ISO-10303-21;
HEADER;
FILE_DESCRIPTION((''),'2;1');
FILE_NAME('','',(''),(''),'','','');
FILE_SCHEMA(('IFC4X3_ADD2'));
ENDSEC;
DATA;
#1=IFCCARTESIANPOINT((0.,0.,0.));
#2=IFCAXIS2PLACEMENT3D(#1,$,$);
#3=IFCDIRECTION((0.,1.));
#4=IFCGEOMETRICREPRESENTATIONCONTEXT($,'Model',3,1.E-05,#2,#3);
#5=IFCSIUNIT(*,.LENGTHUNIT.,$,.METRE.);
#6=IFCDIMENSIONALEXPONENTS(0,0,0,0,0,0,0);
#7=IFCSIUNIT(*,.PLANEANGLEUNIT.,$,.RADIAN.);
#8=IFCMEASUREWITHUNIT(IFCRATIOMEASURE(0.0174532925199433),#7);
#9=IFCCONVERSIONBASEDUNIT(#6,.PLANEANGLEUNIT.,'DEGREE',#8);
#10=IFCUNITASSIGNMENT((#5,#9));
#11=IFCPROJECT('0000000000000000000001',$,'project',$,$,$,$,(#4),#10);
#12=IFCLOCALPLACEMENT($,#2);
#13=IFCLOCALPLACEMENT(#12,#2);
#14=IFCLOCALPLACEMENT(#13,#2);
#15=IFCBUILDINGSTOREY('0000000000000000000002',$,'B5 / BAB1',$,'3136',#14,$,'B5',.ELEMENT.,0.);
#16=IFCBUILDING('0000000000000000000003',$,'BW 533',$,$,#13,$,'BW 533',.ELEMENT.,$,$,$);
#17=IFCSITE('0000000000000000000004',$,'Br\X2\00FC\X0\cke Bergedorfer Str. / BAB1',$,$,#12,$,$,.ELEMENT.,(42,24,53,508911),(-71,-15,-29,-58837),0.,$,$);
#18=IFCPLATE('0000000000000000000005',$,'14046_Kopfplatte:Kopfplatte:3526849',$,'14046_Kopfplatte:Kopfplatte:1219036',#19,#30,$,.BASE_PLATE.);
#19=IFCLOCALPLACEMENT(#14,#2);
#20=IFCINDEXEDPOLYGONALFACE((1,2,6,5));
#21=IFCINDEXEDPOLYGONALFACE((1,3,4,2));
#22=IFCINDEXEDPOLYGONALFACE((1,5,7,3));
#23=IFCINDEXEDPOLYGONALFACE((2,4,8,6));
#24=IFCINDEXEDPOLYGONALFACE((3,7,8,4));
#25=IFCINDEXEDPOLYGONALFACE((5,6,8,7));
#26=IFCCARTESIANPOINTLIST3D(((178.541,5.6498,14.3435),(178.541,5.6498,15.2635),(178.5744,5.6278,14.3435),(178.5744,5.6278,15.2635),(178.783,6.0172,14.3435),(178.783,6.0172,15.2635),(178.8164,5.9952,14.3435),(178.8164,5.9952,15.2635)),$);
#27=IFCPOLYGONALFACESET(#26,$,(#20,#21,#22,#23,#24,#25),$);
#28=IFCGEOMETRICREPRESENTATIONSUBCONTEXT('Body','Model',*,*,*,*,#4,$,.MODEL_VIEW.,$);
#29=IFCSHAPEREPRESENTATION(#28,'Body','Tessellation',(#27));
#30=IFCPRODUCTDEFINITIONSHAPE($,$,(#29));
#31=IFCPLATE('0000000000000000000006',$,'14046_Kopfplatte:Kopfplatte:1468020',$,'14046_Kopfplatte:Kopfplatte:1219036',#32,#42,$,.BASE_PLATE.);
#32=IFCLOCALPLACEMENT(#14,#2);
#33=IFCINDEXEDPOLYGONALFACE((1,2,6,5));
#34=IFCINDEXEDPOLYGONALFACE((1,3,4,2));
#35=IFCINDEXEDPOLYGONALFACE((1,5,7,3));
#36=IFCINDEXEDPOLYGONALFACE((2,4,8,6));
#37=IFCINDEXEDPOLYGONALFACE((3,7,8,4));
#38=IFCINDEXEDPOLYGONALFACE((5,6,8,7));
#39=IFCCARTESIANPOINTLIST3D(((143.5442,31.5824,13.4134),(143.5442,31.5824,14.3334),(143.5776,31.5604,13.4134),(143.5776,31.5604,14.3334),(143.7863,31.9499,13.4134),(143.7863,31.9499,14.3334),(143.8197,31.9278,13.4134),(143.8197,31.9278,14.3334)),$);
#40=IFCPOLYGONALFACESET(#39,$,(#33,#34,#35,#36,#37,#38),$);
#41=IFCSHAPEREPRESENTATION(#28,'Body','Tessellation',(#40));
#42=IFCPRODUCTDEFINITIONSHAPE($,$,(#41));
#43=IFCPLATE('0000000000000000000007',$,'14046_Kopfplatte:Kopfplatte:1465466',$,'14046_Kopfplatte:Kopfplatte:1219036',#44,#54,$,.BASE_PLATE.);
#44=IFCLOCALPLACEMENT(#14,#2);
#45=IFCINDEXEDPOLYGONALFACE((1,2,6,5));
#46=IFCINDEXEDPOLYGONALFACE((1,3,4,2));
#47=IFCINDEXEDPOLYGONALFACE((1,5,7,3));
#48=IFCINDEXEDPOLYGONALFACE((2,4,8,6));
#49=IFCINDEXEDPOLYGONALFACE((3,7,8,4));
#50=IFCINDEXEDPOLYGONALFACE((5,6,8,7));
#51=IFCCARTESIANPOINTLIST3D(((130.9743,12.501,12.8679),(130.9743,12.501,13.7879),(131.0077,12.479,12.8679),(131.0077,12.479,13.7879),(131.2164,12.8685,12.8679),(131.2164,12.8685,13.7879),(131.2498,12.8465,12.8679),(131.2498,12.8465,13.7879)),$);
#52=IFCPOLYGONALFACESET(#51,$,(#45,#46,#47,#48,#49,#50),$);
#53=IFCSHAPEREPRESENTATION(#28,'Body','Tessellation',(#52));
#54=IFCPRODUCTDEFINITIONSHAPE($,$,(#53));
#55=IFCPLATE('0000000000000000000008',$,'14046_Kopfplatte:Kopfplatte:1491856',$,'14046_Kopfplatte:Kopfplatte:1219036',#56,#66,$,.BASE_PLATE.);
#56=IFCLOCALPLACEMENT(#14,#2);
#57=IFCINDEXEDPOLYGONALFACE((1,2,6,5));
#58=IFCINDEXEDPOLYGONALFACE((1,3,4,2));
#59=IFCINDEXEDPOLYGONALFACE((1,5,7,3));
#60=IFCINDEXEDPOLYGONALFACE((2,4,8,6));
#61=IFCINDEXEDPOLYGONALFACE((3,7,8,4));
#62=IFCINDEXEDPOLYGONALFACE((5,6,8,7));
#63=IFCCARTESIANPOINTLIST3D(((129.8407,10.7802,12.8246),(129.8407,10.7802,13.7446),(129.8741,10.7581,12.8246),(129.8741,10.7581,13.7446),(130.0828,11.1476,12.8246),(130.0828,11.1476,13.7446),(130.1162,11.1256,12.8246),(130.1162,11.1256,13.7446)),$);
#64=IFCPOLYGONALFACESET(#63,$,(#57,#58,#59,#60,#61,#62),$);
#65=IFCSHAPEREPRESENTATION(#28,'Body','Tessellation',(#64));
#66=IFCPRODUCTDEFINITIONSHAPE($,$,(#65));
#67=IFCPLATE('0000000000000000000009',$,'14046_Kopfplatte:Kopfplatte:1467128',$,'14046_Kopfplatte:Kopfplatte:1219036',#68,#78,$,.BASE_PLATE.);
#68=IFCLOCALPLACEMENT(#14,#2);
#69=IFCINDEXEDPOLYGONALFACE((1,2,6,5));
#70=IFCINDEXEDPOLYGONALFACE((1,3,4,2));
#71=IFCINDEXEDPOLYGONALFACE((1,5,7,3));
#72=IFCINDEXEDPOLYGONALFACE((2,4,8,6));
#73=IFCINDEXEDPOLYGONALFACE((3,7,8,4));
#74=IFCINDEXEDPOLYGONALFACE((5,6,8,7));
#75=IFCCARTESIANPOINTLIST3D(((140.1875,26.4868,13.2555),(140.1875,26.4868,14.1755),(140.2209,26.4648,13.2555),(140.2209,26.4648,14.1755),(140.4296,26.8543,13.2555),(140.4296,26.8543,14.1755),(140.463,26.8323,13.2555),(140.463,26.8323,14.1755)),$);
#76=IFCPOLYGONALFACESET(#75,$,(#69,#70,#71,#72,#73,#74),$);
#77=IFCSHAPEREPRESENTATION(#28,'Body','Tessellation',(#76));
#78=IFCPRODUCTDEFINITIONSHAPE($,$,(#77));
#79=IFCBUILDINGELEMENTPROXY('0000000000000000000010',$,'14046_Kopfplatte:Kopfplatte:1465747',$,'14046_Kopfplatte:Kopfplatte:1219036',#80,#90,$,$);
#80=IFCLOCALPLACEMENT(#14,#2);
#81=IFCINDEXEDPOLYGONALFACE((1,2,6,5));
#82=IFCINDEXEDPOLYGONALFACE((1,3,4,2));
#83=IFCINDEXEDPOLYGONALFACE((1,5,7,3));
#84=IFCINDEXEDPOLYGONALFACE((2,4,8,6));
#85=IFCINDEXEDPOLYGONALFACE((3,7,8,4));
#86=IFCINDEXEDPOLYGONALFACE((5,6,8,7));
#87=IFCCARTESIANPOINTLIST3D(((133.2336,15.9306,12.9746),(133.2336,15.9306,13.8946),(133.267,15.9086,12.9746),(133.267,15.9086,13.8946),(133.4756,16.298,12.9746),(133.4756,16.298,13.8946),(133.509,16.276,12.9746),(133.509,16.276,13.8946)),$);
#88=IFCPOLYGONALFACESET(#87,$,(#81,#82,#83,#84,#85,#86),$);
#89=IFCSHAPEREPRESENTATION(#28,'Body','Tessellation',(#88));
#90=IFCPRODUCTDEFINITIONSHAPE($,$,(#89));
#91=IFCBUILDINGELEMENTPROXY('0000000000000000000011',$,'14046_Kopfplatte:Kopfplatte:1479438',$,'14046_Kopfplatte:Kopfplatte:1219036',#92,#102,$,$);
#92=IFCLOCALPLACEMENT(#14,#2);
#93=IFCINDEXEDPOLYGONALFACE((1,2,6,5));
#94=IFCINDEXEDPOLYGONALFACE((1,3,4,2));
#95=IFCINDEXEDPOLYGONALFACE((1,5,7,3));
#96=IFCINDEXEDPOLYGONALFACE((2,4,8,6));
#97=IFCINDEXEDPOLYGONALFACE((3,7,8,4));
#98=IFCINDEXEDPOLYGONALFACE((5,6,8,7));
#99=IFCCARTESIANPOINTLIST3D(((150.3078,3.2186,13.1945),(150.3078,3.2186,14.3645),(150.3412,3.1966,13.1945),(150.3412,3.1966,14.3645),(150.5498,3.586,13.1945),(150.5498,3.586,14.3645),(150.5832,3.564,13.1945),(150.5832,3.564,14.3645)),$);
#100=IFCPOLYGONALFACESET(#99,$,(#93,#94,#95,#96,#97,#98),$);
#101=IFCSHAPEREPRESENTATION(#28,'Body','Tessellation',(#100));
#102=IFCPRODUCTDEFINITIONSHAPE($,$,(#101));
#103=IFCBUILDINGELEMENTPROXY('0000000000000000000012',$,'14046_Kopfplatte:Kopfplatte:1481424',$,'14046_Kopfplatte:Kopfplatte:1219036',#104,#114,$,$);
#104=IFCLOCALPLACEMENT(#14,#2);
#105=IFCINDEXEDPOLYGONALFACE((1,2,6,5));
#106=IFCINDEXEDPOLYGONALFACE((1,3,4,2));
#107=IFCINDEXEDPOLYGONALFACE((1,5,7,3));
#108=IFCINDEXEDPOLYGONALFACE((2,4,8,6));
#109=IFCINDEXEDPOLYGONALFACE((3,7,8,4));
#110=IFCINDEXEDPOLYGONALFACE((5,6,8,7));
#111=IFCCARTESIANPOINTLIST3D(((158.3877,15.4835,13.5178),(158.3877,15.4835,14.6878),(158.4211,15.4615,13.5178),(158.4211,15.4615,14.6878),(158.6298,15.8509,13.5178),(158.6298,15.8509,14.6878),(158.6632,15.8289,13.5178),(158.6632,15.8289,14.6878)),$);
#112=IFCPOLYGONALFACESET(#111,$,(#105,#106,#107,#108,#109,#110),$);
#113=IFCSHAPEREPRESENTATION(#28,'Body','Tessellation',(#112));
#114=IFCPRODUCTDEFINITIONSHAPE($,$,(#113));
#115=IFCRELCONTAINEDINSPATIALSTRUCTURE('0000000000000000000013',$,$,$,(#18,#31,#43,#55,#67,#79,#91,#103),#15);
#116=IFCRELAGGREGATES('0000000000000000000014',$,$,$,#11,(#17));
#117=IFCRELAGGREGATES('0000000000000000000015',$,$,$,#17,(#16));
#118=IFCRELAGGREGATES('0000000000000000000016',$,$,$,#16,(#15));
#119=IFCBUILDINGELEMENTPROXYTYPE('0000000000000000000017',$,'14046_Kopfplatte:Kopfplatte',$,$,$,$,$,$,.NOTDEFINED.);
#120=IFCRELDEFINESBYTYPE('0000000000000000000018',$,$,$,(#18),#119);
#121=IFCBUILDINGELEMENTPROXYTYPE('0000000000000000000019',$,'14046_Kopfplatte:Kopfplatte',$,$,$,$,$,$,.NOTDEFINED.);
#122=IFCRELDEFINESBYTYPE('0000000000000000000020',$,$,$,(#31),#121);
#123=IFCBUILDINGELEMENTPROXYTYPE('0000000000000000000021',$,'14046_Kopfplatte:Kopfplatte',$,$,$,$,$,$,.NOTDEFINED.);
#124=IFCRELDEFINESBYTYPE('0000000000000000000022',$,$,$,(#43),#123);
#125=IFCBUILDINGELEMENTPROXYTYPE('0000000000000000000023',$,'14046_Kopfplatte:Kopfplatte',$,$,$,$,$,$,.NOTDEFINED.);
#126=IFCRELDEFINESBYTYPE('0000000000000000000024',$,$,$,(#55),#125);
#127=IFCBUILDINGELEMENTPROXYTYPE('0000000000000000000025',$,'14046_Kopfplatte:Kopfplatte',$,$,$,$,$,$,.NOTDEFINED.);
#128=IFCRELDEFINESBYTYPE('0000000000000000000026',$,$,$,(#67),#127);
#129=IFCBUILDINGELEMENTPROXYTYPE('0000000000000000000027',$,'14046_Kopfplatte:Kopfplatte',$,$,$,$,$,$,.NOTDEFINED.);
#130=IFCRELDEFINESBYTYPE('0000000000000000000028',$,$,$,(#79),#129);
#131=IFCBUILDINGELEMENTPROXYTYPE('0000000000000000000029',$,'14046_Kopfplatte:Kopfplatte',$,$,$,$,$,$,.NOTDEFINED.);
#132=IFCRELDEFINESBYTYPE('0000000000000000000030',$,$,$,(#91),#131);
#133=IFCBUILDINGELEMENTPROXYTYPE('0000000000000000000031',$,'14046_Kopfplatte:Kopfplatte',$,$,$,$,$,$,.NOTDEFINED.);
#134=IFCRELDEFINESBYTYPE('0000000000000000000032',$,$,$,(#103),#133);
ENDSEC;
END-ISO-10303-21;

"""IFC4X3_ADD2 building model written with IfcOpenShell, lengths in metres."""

from ifc_helpers import new_model, entity, si_unit, converted_unit, direction, frame, frame_2d, origin, origin_2d_with_axis, place, context, subcontext, project, spatial, rectangle, extrude, source, transform, mapped, type_object, type_shapes, element, save


model = new_model("IFC4X3_ADD2")

# Units and contexts
model_context = context("Model", 3, precision=1e-05, world=origin(), true_north=direction((0.0, 1.0)))
body_context = subcontext(model_context, "Body", "Model", "MODEL_VIEW")
ifc_project = project(units=[si_unit("LENGTHUNIT", "METRE"), converted_unit("PLANEANGLEUNIT", "DEGREE", entity("IfcRatioMeasure", 0.0174532925199433), si_unit("PLANEANGLEUNIT", "RADIAN"), dimensions=[0, 0, 0, 0, 0, 0, 0])], contexts=[model_context])

# Site, building, storey
site_placement = place(None, origin())
site = spatial("IfcSite", under=ifc_project, at=site_placement, Name="Brücke Bergedorfer Str. / BAB1", CompositionType="ELEMENT", RefLatitude=(42, 24, 53, 508911), RefLongitude=(-71, -15, -29, -58837), RefElevation=0.0)
building_placement = place(site_placement, origin())
building = spatial("IfcBuilding", under=site, at=building_placement, Name="BW 533", LongName="BW 533", CompositionType="ELEMENT")
storey_placement = place(building_placement, origin())
storey = spatial("IfcBuildingStorey", under=building, at=storey_placement, Name="B5 / BAB1", ObjectType="3136", LongName="B5", CompositionType="ELEMENT", Elevation=0.0)

# Plates
building_element_proxy_type_1 = type_object("IfcBuildingElementProxyType", Name="14046_Kopfplatte:Kopfplatte", PredefinedType="NOTDEFINED")
shared_shape_1 = source(origin(), body_context, "Body", "SweptSolid", [
    extrude(rectangle(XDim=0.04, YDim=0.44, at=frame_2d((0.0, 0.0), x_axis=(1.0, 0.0))), frame((178.6787, 5.8225, 14.3435), z_axis=(0.0, 0.0, 1.0), x_axis=(0.835088, -0.550116, 0.0)), (0.0, 0.0, 1.0), 0.92),
])
type_shapes(building_element_proxy_type_1, [shared_shape_1])
plate_1_placement = place(storey_placement, origin())
element("IfcPlate", 1, at=plate_1_placement, inside=storey, type_object=building_element_proxy_type_1, Name="14046_Kopfplatte:Kopfplatte:3526849", ObjectType="14046_Kopfplatte:Kopfplatte:1219036", PredefinedType="BASE_PLATE", context=body_context, shape_type="MappedRepresentation", body=[
    mapped(shared_shape_1, transform((0.0, 0.0, 0.0), scale=1.0)),
])
building_element_proxy_type_2 = type_object("IfcBuildingElementProxyType", Name="14046_Kopfplatte:Kopfplatte", PredefinedType="NOTDEFINED")
shared_shape_2 = source(origin(), body_context, "Body", "SweptSolid", [
    extrude(rectangle(XDim=0.04, YDim=0.44, at=frame_2d((0.0, 0.0), x_axis=(1.0, 0.0))), frame((143.682, 31.7551, 13.4134), z_axis=(0.0, 0.0, 1.0), x_axis=(-0.835088, 0.550116, 0.0)), (0.0, 0.0, 1.0), 0.92),
])
type_shapes(building_element_proxy_type_2, [shared_shape_2])
plate_2_placement = place(storey_placement, origin())
element("IfcPlate", 2, at=plate_2_placement, inside=storey, type_object=building_element_proxy_type_2, Name="14046_Kopfplatte:Kopfplatte:1468020", ObjectType="14046_Kopfplatte:Kopfplatte:1219036", PredefinedType="BASE_PLATE", context=body_context, shape_type="MappedRepresentation", body=[
    mapped(shared_shape_2, transform((0.0, 0.0, 0.0), scale=1.0)),
])
building_element_proxy_type_3 = type_object("IfcBuildingElementProxyType", Name="14046_Kopfplatte:Kopfplatte", PredefinedType="NOTDEFINED")
shared_shape_3 = source(origin(), body_context, "Body", "SweptSolid", [
    extrude(rectangle(XDim=0.04, YDim=0.44, at=frame_2d((0.0, 0.0), x_axis=(1.0, 0.0))), frame((131.1121, 12.6738, 12.8679), z_axis=(0.0, 0.0, 1.0), x_axis=(-0.835088, 0.550116, 0.0)), (0.0, 0.0, 1.0), 0.92),
])
type_shapes(building_element_proxy_type_3, [shared_shape_3])
plate_3_placement = place(storey_placement, origin())
element("IfcPlate", 3, at=plate_3_placement, inside=storey, type_object=building_element_proxy_type_3, Name="14046_Kopfplatte:Kopfplatte:1465466", ObjectType="14046_Kopfplatte:Kopfplatte:1219036", PredefinedType="BASE_PLATE", context=body_context, shape_type="MappedRepresentation", body=[
    mapped(shared_shape_3, transform((0.0, 0.0, 0.0), scale=1.0)),
])
building_element_proxy_type_4 = type_object("IfcBuildingElementProxyType", Name="14046_Kopfplatte:Kopfplatte", PredefinedType="NOTDEFINED")
shared_shape_4 = source(origin(), body_context, "Body", "SweptSolid", [
    extrude(rectangle(XDim=0.04, YDim=0.44, at=frame_2d((0.0, 0.0), x_axis=(1.0, 0.0))), frame((129.9784, 10.9529, 12.8246), z_axis=(0.0, 0.0, 1.0), x_axis=(-0.835088, 0.550116, 0.0)), (0.0, 0.0, 1.0), 0.92),
])
type_shapes(building_element_proxy_type_4, [shared_shape_4])
plate_4_placement = place(storey_placement, origin())
element("IfcPlate", 4, at=plate_4_placement, inside=storey, type_object=building_element_proxy_type_4, Name="14046_Kopfplatte:Kopfplatte:1491856", ObjectType="14046_Kopfplatte:Kopfplatte:1219036", PredefinedType="BASE_PLATE", context=body_context, shape_type="MappedRepresentation", body=[
    mapped(shared_shape_4, transform((0.0, 0.0, 0.0), scale=1.0)),
])
building_element_proxy_type_5 = type_object("IfcBuildingElementProxyType", Name="14046_Kopfplatte:Kopfplatte", PredefinedType="NOTDEFINED")
shared_shape_5 = source(origin(), body_context, "Body", "SweptSolid", [
    extrude(rectangle(XDim=0.04, YDim=0.44, at=frame_2d((0.0, 0.0), x_axis=(1.0, 0.0))), frame((140.3252, 26.6595, 13.2555), z_axis=(0.0, 0.0, 1.0), x_axis=(-0.835088, 0.550116, 0.0)), (0.0, 0.0, 1.0), 0.92),
])
type_shapes(building_element_proxy_type_5, [shared_shape_5])
plate_5_placement = place(storey_placement, origin())
element("IfcPlate", 5, at=plate_5_placement, inside=storey, type_object=building_element_proxy_type_5, Name="14046_Kopfplatte:Kopfplatte:1467128", ObjectType="14046_Kopfplatte:Kopfplatte:1219036", PredefinedType="BASE_PLATE", context=body_context, shape_type="MappedRepresentation", body=[
    mapped(shared_shape_5, transform((0.0, 0.0, 0.0), scale=1.0)),
])

# Building element proxies
building_element_proxy_type_6 = type_object("IfcBuildingElementProxyType", Name="14046_Kopfplatte:Kopfplatte", PredefinedType="NOTDEFINED")
shared_shape_6 = source(origin(), body_context, "Body", "SweptSolid", [
    extrude(rectangle(XDim=0.04, YDim=0.44, at=frame_2d((0.0, 0.0), x_axis=(1.0, 0.0))), frame((133.3713, 16.1033, 12.9746), z_axis=(0.0, 0.0, 1.0), x_axis=(-0.835088, 0.550116, 0.0)), (0.0, 0.0, 1.0), 0.92),
])
type_shapes(building_element_proxy_type_6, [shared_shape_6])
proxy_1_placement = place(storey_placement, origin())
element("IfcBuildingElementProxy", 6, at=proxy_1_placement, inside=storey, type_object=building_element_proxy_type_6, Name="14046_Kopfplatte:Kopfplatte:1465747", ObjectType="14046_Kopfplatte:Kopfplatte:1219036", context=body_context, shape_type="MappedRepresentation", body=[
    mapped(shared_shape_6, transform((0.0, 0.0, 0.0), scale=1.0)),
])
building_element_proxy_type_7 = type_object("IfcBuildingElementProxyType", Name="14046_Kopfplatte:Kopfplatte", PredefinedType="NOTDEFINED")
shared_shape_7 = source(origin(), body_context, "Body", "SweptSolid", [
    extrude(rectangle(XDim=0.04, YDim=0.44, at=origin_2d_with_axis()), frame((150.4455, 3.3913, 13.1945), z_axis=(0.0, 0.0, 1.0), x_axis=(0.835088, -0.550116, 0.0)), (0.0, 0.0, 1.0), 1.17),
])
type_shapes(building_element_proxy_type_7, [shared_shape_7])
proxy_2_placement = place(storey_placement, origin())
element("IfcBuildingElementProxy", 7, at=proxy_2_placement, inside=storey, type_object=building_element_proxy_type_7, Name="14046_Kopfplatte:Kopfplatte:1479438", ObjectType="14046_Kopfplatte:Kopfplatte:1219036", context=body_context, shape_type="MappedRepresentation", body=[
    mapped(shared_shape_7, transform((0.0, 0.0, 0.0), scale=1.0)),
])
building_element_proxy_type_8 = type_object("IfcBuildingElementProxyType", Name="14046_Kopfplatte:Kopfplatte", PredefinedType="NOTDEFINED")
shared_shape_8 = source(origin(), body_context, "Body", "SweptSolid", [
    extrude(rectangle(XDim=0.04, YDim=0.44, at=frame_2d((0.0, 0.0), x_axis=(1.0, 0.0))), frame((158.5254, 15.6562, 13.5178), z_axis=(0.0, 0.0, 1.0), x_axis=(0.835088, -0.550116, 0.0)), (0.0, 0.0, 1.0), 1.17),
])
type_shapes(building_element_proxy_type_8, [shared_shape_8])
proxy_3_placement = place(storey_placement, origin())
element("IfcBuildingElementProxy", 8, at=proxy_3_placement, inside=storey, type_object=building_element_proxy_type_8, Name="14046_Kopfplatte:Kopfplatte:1481424", ObjectType="14046_Kopfplatte:Kopfplatte:1219036", context=body_context, shape_type="MappedRepresentation", body=[
    mapped(shared_shape_8, transform((0.0, 0.0, 0.0), scale=1.0)),
])

save(model, "model.ifc")
